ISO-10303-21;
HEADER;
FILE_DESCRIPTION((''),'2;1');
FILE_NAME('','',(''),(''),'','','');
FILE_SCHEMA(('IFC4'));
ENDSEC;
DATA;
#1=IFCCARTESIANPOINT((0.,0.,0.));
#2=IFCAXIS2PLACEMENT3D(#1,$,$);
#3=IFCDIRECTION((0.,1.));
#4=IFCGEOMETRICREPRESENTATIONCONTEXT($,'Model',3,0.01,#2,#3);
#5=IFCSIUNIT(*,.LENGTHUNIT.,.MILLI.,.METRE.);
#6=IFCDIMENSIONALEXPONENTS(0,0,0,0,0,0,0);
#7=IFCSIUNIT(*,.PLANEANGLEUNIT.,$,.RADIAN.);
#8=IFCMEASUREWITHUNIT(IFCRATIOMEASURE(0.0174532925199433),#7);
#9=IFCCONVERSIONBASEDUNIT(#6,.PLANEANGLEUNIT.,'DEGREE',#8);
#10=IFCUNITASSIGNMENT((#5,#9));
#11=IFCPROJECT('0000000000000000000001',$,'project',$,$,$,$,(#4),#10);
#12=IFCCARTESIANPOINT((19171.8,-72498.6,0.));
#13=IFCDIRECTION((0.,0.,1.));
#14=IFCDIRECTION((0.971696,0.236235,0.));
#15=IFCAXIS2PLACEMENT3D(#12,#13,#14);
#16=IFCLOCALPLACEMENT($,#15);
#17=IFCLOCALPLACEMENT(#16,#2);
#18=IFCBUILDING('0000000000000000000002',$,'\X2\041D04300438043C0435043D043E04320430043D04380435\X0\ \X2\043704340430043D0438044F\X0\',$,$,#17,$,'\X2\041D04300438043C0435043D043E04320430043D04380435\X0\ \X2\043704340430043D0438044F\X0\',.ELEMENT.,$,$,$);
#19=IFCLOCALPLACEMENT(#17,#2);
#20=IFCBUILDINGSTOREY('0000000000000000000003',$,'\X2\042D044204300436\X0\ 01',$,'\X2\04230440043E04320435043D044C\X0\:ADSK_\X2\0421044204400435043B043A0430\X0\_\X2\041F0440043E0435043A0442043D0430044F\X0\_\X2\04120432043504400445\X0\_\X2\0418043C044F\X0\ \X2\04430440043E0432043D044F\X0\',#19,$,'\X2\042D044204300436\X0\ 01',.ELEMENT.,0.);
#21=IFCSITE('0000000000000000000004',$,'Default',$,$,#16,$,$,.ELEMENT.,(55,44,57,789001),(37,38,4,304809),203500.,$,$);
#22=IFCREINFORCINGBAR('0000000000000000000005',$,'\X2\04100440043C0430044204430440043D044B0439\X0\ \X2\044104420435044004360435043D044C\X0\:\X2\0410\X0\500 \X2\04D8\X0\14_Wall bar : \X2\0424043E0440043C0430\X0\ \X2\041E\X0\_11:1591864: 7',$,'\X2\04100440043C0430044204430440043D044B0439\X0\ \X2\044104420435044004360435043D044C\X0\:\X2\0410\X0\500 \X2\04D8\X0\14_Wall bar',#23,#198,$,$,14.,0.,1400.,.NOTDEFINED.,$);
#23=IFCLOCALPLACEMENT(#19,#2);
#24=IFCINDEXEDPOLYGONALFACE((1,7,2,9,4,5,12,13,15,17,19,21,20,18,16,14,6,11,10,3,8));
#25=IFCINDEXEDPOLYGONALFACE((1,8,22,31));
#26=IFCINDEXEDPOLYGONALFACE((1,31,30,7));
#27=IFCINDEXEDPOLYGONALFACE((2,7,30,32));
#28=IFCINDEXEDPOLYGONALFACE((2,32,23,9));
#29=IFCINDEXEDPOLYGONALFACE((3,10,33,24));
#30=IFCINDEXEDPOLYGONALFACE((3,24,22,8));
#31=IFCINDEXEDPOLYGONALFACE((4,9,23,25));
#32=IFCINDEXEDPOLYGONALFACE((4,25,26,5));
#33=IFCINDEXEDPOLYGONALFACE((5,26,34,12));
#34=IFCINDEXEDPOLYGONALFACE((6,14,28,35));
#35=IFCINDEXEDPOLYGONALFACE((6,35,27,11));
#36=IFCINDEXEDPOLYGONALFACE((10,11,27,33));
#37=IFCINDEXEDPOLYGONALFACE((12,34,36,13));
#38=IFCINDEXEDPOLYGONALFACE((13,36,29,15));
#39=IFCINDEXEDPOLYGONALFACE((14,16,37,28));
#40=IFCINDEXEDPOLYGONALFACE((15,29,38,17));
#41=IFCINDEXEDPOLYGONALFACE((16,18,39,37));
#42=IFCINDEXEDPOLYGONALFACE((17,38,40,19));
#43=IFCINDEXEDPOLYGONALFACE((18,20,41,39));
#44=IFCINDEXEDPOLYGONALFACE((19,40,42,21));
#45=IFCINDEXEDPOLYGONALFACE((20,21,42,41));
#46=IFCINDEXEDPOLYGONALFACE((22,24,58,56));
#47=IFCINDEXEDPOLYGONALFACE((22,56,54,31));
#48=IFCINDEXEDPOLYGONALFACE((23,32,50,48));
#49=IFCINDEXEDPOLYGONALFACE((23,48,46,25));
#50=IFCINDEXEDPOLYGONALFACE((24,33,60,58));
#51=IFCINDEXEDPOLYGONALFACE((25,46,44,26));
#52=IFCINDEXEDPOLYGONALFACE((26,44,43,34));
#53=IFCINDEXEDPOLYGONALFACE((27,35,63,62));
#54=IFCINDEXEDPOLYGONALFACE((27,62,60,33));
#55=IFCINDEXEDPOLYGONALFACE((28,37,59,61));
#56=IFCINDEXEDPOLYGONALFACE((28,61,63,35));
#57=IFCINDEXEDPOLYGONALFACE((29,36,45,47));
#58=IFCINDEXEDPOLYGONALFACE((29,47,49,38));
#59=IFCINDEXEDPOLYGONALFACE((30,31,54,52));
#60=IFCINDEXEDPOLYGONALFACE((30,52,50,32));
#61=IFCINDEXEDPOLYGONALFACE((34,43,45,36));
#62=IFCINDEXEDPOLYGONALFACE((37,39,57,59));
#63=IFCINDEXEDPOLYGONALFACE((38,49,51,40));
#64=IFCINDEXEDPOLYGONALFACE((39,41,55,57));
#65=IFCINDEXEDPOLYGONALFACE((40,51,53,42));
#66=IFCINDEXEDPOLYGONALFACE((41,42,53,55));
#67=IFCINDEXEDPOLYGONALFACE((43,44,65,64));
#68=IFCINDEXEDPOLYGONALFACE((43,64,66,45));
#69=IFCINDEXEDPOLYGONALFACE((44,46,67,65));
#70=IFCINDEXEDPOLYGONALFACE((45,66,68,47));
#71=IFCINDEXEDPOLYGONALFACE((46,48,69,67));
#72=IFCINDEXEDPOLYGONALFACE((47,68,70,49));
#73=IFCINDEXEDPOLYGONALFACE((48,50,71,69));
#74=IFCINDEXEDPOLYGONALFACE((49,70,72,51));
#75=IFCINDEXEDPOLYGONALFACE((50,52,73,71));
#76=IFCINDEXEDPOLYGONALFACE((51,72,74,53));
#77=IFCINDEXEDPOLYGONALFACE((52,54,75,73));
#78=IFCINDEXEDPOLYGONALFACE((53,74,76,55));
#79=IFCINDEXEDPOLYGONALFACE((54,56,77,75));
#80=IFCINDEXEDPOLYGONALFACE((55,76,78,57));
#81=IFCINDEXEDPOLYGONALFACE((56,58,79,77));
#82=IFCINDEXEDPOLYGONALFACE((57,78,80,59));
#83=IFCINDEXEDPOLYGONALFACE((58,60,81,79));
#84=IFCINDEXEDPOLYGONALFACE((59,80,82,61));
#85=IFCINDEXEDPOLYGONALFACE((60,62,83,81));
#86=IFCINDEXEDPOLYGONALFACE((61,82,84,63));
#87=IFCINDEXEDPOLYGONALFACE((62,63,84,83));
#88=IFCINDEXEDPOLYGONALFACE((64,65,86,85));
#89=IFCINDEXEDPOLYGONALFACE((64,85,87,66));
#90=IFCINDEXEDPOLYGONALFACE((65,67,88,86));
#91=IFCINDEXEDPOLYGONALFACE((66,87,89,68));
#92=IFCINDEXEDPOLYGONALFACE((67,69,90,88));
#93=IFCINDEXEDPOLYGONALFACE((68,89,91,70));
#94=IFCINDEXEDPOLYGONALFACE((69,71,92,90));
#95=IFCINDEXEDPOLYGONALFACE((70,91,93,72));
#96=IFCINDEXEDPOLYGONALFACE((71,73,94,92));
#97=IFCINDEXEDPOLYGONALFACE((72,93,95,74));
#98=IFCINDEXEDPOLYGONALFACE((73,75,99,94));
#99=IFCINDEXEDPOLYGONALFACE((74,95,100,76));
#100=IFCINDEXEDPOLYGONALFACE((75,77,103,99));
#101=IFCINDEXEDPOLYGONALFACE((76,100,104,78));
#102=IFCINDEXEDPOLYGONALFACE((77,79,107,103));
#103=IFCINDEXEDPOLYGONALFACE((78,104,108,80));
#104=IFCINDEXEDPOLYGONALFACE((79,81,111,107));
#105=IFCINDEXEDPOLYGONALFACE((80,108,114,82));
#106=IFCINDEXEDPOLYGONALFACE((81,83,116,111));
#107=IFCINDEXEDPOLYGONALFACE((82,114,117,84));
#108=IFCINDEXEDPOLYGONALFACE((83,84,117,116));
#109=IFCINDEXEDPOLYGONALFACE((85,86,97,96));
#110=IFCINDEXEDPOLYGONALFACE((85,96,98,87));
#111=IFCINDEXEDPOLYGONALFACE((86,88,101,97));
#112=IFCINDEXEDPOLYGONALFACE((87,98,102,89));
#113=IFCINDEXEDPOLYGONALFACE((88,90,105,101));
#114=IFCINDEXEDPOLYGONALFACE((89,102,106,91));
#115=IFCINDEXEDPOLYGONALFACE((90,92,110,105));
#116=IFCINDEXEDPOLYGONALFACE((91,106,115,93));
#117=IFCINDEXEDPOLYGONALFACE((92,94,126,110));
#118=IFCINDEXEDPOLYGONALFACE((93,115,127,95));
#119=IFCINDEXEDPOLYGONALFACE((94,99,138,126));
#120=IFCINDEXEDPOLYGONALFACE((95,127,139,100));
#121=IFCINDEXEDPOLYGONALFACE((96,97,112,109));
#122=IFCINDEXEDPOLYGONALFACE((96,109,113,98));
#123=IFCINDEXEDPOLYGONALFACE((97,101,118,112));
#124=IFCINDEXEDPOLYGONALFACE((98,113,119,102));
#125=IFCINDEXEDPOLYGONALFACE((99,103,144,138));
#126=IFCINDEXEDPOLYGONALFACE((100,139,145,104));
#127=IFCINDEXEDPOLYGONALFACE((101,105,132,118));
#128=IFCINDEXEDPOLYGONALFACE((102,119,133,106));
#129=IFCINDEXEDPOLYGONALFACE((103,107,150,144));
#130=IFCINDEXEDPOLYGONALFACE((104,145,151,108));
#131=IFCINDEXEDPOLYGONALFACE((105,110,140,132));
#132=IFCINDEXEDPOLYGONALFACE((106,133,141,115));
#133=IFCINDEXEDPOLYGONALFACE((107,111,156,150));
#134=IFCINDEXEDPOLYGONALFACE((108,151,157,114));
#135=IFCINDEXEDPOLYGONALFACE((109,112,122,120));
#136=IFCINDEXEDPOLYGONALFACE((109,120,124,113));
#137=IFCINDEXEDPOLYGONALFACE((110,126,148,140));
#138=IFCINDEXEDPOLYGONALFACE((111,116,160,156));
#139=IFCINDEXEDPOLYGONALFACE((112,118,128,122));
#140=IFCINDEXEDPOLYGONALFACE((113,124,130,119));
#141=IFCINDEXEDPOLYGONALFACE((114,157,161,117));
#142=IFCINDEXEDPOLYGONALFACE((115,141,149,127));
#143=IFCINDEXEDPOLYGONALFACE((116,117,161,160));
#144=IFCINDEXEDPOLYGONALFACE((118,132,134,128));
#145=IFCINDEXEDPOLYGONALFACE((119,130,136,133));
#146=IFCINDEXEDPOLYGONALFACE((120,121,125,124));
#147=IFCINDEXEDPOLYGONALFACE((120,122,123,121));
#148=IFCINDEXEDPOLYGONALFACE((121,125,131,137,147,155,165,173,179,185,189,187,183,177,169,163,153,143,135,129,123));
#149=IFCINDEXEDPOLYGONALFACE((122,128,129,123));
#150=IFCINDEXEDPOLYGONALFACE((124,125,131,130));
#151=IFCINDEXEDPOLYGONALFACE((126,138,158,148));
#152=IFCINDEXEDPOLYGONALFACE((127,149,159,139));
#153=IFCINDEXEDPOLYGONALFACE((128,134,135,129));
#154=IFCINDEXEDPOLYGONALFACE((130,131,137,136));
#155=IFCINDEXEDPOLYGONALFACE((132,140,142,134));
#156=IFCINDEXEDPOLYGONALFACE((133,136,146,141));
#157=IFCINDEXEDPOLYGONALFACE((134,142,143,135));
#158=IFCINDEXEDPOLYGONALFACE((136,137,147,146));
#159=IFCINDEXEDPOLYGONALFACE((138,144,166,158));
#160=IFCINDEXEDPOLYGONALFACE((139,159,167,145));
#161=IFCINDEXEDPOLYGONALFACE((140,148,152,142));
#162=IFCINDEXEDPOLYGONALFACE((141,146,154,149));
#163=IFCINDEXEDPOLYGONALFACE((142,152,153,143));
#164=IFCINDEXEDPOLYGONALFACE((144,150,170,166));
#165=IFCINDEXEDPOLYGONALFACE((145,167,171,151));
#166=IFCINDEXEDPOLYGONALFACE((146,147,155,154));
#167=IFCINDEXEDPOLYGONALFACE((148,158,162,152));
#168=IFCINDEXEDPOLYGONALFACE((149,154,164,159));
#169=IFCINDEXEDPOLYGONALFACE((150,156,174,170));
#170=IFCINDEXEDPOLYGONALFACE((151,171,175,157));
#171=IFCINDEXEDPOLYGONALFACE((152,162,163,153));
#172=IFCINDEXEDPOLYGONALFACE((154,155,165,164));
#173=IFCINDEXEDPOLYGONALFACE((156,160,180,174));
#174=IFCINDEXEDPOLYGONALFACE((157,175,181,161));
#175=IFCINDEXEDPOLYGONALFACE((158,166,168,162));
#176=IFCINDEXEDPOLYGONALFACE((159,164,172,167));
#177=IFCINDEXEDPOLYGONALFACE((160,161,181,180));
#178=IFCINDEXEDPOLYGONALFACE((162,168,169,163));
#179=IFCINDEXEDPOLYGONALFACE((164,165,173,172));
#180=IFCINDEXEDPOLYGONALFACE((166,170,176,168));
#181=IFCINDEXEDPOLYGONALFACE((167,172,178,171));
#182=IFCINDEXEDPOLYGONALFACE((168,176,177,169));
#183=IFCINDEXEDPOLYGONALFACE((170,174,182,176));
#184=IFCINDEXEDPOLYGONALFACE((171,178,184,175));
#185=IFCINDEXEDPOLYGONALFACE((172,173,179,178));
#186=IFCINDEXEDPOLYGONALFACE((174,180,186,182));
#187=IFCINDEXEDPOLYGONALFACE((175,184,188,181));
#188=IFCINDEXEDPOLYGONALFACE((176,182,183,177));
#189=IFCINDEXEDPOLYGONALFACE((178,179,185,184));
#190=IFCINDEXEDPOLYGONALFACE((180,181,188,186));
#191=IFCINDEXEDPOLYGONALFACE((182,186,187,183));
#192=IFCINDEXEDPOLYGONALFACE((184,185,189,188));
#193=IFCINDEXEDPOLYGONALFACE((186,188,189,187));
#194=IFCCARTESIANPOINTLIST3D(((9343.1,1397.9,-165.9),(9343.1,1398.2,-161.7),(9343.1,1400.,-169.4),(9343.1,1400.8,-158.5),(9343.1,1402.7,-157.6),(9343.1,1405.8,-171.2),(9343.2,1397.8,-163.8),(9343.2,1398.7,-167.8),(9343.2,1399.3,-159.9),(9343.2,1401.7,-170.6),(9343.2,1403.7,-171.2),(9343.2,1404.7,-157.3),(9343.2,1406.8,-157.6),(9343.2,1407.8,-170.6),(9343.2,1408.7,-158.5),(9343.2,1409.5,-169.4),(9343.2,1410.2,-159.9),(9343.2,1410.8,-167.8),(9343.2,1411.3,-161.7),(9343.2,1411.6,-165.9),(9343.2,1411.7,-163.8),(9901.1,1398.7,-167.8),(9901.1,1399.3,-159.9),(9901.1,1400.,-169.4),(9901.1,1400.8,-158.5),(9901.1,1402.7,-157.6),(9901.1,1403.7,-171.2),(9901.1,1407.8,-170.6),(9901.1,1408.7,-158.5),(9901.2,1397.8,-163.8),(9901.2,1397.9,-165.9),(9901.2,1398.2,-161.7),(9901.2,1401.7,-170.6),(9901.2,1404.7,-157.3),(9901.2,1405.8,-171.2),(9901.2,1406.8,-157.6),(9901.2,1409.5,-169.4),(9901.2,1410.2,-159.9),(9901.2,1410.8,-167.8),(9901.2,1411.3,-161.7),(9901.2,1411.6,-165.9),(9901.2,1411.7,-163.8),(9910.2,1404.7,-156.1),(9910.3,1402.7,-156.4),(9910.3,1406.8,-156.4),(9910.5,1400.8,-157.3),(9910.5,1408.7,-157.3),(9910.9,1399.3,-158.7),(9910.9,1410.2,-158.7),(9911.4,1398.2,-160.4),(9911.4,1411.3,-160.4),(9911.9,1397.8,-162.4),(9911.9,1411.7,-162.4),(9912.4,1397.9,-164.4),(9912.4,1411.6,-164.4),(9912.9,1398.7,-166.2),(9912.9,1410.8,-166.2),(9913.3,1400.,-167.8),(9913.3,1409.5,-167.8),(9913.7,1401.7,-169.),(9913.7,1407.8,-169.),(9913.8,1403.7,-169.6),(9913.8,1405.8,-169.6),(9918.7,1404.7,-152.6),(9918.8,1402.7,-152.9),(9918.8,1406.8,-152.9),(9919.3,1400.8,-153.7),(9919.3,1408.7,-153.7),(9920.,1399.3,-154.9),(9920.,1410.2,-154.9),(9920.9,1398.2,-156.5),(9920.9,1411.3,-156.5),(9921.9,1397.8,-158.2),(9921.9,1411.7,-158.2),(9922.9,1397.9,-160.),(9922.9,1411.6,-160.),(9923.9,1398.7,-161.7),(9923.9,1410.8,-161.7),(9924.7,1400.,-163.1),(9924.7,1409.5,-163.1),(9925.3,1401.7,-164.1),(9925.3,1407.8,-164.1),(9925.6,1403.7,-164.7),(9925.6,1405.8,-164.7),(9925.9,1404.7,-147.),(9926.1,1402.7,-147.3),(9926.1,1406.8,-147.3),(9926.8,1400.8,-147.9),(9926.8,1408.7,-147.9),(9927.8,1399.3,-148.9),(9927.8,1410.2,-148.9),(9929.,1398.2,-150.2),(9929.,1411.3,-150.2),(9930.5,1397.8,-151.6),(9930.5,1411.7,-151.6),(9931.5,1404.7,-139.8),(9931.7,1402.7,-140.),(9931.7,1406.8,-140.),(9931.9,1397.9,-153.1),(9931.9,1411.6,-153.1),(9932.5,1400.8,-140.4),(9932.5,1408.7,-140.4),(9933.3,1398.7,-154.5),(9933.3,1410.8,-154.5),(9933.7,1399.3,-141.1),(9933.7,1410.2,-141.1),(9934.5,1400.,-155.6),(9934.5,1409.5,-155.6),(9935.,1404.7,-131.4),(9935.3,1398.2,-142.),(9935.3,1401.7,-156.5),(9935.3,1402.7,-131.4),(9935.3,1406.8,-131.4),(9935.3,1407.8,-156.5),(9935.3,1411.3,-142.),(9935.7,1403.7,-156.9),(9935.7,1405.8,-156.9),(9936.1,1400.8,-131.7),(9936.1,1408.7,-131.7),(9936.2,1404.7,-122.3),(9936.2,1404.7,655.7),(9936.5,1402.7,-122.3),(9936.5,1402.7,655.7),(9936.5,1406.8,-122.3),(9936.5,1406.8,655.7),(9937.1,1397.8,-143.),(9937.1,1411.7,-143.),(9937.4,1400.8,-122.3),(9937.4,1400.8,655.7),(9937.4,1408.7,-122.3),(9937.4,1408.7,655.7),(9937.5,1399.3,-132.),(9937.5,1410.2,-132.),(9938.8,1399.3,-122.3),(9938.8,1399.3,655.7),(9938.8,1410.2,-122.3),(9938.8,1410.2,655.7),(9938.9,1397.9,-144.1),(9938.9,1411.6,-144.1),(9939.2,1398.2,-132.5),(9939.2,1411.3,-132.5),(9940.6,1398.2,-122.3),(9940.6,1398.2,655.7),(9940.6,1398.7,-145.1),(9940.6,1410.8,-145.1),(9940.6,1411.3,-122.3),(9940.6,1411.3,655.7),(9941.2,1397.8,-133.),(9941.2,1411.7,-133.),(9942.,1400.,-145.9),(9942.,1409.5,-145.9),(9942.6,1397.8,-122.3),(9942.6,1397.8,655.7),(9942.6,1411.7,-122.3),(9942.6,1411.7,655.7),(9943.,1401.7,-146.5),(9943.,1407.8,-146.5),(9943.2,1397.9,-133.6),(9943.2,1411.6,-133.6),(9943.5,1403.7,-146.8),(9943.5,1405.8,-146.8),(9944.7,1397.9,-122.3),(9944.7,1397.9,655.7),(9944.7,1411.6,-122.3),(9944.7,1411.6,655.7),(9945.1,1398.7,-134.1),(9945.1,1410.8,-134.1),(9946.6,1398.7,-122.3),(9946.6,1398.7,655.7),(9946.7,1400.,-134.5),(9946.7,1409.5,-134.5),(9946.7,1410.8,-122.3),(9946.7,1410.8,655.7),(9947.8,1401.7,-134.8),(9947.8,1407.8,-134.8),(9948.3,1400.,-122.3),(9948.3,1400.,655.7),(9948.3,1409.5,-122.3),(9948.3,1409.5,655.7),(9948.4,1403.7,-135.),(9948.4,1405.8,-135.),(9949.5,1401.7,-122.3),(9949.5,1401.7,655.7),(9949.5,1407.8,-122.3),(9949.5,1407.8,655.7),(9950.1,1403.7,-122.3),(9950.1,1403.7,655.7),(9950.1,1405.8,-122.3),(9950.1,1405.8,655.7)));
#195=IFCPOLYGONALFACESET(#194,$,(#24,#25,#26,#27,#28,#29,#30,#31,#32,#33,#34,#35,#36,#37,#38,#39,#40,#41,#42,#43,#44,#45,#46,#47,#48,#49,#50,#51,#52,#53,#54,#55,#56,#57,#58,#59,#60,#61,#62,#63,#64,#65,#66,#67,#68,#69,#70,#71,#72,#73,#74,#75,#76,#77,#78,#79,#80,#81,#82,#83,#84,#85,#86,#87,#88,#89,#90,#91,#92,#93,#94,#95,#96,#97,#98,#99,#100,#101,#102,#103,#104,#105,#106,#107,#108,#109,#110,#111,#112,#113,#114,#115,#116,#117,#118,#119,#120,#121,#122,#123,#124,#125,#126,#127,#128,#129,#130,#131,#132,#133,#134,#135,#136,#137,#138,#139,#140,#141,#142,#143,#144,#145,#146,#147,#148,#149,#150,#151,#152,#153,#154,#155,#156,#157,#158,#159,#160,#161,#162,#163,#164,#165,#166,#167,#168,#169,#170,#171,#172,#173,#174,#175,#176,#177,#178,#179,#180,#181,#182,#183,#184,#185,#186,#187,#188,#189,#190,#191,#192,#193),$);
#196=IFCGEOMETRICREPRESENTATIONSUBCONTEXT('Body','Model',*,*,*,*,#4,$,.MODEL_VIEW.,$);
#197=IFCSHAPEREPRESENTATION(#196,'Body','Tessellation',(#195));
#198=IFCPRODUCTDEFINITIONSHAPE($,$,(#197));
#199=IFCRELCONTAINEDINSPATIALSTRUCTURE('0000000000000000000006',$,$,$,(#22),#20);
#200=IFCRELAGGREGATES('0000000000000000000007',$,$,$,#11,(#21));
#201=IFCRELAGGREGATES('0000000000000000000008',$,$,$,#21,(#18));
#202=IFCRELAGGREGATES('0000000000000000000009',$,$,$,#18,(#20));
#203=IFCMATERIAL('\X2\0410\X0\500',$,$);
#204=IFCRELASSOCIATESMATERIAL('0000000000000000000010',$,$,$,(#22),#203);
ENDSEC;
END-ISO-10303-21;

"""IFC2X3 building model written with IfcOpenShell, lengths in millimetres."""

from ifc_helpers import new_model, entity, si_unit, converted_unit, direction, frame, origin, place, context, subcontext, project, spatial, material, element, save


model = new_model("IFC2X3")

# Units and contexts
model_context = context("Model", 3, precision=0.01, world=origin(), true_north=direction((0.0, 1.0)))
body_context = subcontext(model_context, "Body", "Model", "MODEL_VIEW")
ifc_project = project(units=[si_unit("LENGTHUNIT", "METRE", prefix="MILLI"), converted_unit("PLANEANGLEUNIT", "DEGREE", entity("IfcRatioMeasure", 0.0174532925199433), si_unit("PLANEANGLEUNIT", "RADIAN"), dimensions=[0, 0, 0, 0, 0, 0, 0])], contexts=[model_context])

# Site, building, storey
site_placement = place(None, frame((19171.8, -72498.6, 0.0), z_axis=(0.0, 0.0, 1.0), x_axis=(0.971696, 0.236235, 0.0)))
site = spatial("IfcSite", under=ifc_project, at=site_placement, Name="Default", CompositionType="ELEMENT", RefLatitude=(55, 44, 57, 789001), RefLongitude=(37, 38, 4, 304809), RefElevation=203500.0)
building_placement = place(site_placement, origin())
building = spatial("IfcBuilding", under=site, at=building_placement, Name="Наименование здания", LongName="Наименование здания", CompositionType="ELEMENT")
storey_placement = place(building_placement, origin())
storey = spatial("IfcBuildingStorey", under=building, at=storey_placement, Name="Этаж 01", ObjectType="Уровень:ADSK_Стрелка_Проектная_Вверх_Имя уровня", LongName="Этаж 01", CompositionType="ELEMENT", Elevation=0.0)

# Reinforcing bar
ifc_material = material(Name="А500")
placement = place(storey_placement, origin())
element("IfcReinforcingBar", 1, at=placement, inside=storey, material=ifc_material, Name="Арматурный стержень:А500 Ә14_Wall bar : Форма О_11:1591864: 7", ObjectType="Арматурный стержень:А500 Ә14_Wall bar", BarLength=1400.0, BarRole="NOTDEFINED", CrossSectionArea=0.0, NominalDiameter=14.0, context=body_context, shape_type="AdvancedSweptSolid", body=[
    entity("IfcSweptDiskSolid", entity("IfcCompositeCurve", [entity("IfcCompositeCurveSegment", "CONTINUOUS", True, entity("IfcPolyline", [entity("IfcCartesianPoint", [9943.1, 1404.7, 655.7]), entity("IfcCartesianPoint", [9943.1, 1404.7, -122.3])])), entity("IfcCompositeCurveSegment", "CONTINUOUS", True, entity("IfcTrimmedCurve", entity("IfcCircle", entity("IfcAxis2Placement3D", entity("IfcCartesianPoint", [9901.1, 1404.7, -122.3]), entity("IfcDirection", [0.0, 1.0, 0.0]), entity("IfcDirection", [0.0, 0.0, -1.0])), 42.0), [entity("IfcParameterValue", 270.0)], [entity("IfcParameterValue", 360.0)], True, "PARAMETER")), entity("IfcCompositeCurveSegment", "CONTINUOUS", True, entity("IfcPolyline", [entity("IfcCartesianPoint", [9901.1, 1404.7, -164.3]), entity("IfcCartesianPoint", [9343.1, 1404.7, -164.3])]))], False), 7.0, None, 0.0, 92.0),
])

save(model, "model.ifc")
